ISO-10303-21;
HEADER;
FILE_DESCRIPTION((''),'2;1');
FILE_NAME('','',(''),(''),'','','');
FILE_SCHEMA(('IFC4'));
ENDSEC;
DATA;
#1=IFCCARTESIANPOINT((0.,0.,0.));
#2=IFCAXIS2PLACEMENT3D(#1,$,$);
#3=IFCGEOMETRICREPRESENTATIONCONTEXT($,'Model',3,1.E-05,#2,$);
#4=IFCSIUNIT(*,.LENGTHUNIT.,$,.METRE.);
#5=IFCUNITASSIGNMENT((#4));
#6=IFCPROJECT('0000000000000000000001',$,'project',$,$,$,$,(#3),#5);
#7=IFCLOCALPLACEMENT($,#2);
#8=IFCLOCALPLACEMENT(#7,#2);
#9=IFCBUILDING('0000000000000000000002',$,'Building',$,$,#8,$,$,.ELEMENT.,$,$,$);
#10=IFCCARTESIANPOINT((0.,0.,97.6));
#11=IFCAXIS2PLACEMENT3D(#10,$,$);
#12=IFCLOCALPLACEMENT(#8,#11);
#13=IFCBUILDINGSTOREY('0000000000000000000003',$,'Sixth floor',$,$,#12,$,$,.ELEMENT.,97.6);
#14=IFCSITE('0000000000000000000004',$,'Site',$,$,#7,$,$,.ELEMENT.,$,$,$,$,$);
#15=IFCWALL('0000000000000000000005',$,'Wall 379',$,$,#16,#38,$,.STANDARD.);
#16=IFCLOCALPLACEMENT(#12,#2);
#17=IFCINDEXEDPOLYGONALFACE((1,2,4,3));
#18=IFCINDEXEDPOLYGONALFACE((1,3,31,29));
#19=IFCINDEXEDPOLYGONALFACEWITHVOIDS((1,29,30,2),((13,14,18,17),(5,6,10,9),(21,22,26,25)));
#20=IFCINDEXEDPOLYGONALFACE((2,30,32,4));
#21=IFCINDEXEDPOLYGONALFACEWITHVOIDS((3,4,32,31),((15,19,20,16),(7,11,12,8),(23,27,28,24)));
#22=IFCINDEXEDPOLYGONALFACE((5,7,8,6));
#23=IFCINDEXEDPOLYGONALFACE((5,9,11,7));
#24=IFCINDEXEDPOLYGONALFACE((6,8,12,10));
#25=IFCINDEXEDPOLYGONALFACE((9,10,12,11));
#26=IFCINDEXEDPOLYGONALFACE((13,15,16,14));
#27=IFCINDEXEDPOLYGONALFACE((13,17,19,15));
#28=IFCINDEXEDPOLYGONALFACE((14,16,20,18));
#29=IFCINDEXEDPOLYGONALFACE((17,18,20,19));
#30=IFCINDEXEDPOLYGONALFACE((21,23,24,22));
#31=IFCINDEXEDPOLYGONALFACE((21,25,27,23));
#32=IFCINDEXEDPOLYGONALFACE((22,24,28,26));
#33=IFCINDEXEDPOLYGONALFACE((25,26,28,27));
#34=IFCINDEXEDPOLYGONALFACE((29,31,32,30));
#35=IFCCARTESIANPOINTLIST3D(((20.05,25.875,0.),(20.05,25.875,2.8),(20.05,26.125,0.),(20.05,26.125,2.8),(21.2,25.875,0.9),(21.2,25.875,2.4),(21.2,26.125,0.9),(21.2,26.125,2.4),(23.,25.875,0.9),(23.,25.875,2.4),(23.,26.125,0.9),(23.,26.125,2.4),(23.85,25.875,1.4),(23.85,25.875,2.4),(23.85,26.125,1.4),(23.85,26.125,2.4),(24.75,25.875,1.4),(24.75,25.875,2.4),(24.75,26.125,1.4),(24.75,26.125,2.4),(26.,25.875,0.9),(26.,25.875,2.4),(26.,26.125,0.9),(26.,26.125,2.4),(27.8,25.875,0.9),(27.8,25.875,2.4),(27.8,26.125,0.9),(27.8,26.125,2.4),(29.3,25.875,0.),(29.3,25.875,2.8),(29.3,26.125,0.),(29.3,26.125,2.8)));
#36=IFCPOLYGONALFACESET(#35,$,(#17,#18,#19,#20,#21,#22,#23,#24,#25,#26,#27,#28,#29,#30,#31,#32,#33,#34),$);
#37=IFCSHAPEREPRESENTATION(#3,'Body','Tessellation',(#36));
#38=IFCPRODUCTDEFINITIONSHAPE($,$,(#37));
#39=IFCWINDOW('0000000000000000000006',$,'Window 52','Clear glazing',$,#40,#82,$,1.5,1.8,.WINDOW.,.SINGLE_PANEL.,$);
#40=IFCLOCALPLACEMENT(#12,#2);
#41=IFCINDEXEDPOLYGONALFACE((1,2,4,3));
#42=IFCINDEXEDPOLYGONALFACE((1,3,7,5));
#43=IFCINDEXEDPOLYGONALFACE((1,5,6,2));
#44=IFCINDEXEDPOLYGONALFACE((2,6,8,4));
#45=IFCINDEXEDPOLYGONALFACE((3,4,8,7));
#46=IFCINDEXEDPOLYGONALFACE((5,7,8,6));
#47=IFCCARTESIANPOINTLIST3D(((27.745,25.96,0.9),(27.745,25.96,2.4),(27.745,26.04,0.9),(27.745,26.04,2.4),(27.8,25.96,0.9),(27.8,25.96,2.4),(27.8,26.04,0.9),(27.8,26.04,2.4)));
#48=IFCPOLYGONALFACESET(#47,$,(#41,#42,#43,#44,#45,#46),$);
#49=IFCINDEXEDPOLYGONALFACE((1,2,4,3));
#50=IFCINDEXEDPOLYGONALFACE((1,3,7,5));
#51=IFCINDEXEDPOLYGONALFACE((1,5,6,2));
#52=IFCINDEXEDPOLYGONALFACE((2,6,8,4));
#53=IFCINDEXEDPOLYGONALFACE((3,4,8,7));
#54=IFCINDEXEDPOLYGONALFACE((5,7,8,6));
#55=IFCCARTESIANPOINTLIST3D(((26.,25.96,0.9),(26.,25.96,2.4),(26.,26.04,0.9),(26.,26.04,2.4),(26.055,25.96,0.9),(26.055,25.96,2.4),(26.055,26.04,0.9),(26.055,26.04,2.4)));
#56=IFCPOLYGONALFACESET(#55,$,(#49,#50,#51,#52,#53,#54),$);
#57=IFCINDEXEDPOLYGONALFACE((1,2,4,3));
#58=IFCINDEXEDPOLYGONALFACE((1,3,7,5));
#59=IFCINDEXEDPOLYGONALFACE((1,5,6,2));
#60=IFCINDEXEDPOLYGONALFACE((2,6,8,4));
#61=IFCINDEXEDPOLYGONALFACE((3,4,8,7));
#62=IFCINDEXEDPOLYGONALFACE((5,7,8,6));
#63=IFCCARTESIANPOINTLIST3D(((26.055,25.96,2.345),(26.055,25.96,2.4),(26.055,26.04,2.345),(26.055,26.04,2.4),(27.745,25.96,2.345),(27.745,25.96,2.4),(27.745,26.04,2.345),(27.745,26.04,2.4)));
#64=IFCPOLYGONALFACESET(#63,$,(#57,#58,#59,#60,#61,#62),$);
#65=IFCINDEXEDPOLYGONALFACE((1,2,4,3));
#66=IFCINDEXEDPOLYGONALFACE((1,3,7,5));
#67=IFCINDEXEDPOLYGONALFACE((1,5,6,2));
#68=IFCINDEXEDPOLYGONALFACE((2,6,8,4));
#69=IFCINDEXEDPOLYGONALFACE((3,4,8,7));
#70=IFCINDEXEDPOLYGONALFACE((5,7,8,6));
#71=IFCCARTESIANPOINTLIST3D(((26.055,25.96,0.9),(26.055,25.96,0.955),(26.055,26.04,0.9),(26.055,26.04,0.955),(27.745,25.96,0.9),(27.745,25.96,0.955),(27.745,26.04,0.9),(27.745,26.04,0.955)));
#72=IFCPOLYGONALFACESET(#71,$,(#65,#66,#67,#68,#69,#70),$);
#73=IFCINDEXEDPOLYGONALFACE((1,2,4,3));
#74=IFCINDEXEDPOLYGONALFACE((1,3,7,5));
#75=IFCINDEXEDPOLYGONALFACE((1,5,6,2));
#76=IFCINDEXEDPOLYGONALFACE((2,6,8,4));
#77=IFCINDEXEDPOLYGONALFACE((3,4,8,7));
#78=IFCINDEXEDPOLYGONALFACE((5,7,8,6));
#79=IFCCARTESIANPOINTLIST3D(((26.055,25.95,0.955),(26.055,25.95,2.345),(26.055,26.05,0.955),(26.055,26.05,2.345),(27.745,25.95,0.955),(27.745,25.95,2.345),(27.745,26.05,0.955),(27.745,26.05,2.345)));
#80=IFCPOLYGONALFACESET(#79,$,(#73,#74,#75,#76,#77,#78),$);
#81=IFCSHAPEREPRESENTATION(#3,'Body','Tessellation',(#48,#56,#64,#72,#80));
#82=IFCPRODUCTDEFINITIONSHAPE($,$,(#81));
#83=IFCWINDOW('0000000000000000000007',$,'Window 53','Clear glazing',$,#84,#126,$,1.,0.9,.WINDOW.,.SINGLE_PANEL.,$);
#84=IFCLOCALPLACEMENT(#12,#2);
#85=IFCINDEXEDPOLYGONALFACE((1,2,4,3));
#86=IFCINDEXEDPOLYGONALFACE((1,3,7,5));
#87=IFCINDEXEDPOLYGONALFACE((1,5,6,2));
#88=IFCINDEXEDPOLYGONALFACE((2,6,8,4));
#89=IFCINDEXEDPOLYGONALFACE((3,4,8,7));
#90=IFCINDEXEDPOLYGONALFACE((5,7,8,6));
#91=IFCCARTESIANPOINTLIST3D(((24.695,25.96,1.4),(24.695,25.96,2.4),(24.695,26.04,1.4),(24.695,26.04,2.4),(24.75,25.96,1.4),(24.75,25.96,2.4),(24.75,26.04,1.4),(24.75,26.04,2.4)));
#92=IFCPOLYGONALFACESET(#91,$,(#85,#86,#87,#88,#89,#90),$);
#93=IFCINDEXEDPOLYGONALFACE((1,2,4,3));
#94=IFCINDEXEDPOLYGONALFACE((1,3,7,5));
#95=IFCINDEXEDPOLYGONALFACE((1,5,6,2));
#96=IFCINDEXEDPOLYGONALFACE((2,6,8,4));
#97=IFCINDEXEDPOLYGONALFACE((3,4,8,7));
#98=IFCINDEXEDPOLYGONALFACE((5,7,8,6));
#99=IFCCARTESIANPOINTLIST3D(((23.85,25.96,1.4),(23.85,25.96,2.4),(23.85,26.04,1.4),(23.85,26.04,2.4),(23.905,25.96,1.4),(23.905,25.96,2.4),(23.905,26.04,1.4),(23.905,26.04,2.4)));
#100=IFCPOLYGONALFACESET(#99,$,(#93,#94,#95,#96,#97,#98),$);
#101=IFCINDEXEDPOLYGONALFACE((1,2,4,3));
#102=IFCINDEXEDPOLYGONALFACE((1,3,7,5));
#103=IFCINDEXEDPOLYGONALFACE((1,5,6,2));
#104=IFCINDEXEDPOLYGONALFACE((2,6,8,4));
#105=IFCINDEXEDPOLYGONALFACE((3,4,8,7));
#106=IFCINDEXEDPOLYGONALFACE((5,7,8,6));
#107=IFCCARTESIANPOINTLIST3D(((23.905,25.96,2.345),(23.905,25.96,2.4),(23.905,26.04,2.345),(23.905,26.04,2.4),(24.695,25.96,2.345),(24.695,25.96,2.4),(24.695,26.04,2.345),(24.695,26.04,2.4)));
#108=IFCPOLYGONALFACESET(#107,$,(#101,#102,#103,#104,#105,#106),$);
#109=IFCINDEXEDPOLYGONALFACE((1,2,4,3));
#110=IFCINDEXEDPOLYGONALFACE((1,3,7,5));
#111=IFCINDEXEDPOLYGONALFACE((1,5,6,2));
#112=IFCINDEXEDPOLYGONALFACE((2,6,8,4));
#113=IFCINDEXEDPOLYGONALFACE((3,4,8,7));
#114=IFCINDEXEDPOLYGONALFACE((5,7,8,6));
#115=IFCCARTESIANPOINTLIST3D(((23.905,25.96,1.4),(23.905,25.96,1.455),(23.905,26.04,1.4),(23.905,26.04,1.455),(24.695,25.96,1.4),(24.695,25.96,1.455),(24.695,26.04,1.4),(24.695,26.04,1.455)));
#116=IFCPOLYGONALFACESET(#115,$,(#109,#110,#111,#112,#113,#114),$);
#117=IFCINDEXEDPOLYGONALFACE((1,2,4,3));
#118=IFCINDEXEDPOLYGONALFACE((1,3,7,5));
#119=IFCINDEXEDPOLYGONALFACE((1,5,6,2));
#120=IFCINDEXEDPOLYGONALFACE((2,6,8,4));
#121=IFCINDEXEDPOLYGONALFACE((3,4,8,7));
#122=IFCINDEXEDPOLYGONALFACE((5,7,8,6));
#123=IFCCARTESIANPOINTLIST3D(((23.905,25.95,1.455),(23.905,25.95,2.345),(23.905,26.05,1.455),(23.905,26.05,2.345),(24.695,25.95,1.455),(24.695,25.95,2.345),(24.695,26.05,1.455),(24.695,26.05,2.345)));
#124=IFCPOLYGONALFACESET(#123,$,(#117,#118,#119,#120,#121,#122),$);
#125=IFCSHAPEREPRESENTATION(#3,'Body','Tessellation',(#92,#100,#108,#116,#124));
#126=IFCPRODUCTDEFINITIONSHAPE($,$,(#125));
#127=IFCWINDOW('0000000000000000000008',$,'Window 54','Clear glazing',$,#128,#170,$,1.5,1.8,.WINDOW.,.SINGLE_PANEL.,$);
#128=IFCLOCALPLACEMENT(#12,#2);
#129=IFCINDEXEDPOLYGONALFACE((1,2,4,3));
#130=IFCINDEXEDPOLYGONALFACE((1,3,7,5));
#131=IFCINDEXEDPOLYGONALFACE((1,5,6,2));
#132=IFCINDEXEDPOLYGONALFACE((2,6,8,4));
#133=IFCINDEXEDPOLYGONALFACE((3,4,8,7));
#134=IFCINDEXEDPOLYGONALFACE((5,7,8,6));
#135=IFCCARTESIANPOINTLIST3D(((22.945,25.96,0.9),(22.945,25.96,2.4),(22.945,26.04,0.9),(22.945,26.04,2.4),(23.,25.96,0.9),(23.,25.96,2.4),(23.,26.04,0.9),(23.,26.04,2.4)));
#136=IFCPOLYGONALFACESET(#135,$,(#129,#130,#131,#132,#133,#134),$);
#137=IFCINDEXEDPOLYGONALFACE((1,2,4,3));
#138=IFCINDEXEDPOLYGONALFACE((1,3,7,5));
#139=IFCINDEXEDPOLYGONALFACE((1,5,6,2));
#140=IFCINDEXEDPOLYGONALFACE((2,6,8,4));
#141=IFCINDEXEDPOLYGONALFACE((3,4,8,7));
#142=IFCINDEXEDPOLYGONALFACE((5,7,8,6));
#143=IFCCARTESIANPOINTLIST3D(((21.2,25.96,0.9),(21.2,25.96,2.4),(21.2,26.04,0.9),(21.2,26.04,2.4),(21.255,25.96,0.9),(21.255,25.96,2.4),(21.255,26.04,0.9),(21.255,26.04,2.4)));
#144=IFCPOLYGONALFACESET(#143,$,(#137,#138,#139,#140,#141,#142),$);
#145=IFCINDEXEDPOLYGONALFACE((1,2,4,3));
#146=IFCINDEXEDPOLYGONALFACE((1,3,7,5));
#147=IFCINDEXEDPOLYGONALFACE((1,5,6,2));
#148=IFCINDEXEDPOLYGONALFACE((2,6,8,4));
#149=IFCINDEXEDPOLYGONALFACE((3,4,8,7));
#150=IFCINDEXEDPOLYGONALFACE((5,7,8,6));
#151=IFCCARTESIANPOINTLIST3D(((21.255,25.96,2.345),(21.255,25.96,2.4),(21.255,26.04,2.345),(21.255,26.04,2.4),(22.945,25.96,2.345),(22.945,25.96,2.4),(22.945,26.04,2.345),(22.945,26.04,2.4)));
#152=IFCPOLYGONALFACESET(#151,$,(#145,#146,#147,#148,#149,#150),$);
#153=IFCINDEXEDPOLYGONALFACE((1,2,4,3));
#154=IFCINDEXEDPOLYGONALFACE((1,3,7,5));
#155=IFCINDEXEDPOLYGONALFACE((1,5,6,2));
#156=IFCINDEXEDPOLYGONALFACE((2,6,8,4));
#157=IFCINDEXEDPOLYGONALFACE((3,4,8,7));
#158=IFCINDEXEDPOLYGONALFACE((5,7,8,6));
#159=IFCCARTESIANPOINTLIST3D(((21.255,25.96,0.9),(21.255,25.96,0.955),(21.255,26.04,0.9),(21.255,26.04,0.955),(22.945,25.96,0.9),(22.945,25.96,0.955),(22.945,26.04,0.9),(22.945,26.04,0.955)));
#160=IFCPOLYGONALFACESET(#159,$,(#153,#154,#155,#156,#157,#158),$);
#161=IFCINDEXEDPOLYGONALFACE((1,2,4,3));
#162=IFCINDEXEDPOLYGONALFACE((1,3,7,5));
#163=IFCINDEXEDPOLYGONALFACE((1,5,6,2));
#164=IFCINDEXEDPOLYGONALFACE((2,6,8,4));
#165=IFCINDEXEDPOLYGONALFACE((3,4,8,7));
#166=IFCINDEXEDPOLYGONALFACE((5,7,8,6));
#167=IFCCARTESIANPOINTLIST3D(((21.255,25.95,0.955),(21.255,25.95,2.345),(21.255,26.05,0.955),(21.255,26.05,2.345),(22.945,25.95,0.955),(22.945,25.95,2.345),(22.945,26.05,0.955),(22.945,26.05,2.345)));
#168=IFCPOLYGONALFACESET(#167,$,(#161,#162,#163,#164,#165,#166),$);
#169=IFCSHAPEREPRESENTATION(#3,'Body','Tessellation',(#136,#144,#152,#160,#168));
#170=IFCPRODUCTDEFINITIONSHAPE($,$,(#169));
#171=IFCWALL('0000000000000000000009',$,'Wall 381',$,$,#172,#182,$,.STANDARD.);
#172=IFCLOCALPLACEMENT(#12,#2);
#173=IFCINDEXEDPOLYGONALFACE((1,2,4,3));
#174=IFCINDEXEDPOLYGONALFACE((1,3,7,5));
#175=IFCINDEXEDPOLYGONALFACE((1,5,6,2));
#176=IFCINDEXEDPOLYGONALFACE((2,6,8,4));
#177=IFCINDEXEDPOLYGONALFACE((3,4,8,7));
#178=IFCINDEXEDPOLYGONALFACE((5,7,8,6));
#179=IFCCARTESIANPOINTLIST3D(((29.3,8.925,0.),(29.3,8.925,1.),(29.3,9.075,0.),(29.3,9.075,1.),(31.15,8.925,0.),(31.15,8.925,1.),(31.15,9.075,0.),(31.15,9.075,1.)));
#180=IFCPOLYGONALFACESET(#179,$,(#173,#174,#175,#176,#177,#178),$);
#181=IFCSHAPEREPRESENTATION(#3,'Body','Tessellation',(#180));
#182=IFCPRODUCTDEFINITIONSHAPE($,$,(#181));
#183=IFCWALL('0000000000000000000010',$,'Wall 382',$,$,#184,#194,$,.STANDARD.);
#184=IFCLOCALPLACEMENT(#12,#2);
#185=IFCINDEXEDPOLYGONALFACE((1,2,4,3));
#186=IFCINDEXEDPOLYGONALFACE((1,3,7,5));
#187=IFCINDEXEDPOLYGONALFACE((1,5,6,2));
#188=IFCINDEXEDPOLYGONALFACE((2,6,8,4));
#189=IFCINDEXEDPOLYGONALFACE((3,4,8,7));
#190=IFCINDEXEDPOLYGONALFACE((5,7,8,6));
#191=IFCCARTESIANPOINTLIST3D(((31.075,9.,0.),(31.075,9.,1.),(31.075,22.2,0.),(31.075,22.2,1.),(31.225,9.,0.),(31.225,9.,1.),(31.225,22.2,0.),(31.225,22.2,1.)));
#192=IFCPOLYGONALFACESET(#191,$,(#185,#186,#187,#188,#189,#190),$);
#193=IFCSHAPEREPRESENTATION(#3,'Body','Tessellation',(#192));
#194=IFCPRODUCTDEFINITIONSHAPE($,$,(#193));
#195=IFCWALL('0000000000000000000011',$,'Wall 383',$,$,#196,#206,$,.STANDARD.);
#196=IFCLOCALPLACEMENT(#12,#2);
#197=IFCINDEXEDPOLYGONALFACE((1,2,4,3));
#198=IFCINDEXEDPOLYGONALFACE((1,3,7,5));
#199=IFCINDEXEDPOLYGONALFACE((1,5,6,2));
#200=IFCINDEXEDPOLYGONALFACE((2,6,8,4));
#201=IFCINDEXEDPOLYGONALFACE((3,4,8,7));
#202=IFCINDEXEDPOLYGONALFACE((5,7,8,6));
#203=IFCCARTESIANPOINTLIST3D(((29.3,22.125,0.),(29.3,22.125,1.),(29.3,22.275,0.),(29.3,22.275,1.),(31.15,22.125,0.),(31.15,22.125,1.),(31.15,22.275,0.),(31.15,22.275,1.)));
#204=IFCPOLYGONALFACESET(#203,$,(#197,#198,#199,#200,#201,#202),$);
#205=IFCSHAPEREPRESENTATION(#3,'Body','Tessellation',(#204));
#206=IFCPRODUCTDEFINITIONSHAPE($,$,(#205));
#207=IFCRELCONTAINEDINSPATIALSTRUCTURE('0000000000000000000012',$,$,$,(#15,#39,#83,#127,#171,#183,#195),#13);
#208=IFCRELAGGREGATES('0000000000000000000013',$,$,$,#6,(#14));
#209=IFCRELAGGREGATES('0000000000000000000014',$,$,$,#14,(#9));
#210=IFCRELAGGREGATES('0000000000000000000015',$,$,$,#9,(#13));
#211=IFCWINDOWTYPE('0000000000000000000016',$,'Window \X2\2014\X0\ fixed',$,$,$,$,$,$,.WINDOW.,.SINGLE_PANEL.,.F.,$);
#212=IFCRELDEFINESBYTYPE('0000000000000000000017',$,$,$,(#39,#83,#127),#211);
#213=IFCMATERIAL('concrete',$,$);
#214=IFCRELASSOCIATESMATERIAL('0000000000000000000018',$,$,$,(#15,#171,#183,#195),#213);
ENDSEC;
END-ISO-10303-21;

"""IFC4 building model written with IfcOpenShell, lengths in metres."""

from ifc_helpers import new_model, si_unit, frame, frame_2d, origin, place, context, project, spatial, rectangle, extrude, material, type_object, element, fill, save


model = new_model("IFC4")

# Units and contexts
model_context = context("Model", 3, precision=1e-05, world=origin())
ifc_project = project(units=[si_unit("LENGTHUNIT", "METRE")], contexts=[model_context])

# Site, building, storey
site_placement = place(None, origin())
site = spatial("IfcSite", under=ifc_project, at=site_placement, Name="Site", CompositionType="ELEMENT")
building_placement = place(site_placement, origin())
building = spatial("IfcBuilding", under=site, at=building_placement, Name="Building", CompositionType="ELEMENT")
storey_placement = place(building_placement, frame((0.0, 0.0, 97.6)))
storey = spatial("IfcBuildingStorey", under=building, at=storey_placement, Name="Sixth floor", CompositionType="ELEMENT", Elevation=97.6)

# Shared definitions
ifc_material = material(Name="concrete")

# Shared definitions
window_type = type_object("IfcWindowType", Name="Window — fixed", ParameterTakesPrecedence=False, PartitioningType="SINGLE_PANEL", PredefinedType="WINDOW")

# Wall, openings, windows
wall_1_placement = place(storey_placement, frame((29.3, 26.0, 0.0), z_axis=(0.0, 0.0, 1.0), x_axis=(-1.0, 0.0, 0.0)))
wall_1 = element("IfcWall", 1, at=wall_1_placement, inside=storey, material=ifc_material, Name="Wall 379", PredefinedType="STANDARD", context=model_context, shape_type="SweptSolid", body=[
    extrude(rectangle(XDim=9.25, YDim=0.25, at=frame_2d((4.625, 0.0))), origin(), (0.0, 0.0, 1.0), 2.8),
])
opening_1_placement = place(storey_placement, frame((27.8, 26.0, 0.9), z_axis=(0.0, 0.0, 1.0), x_axis=(-1.0, 0.0, 0.0)))
opening_1 = element("IfcOpeningElement", 2, at=opening_1_placement, cuts=wall_1, PredefinedType="OPENING", context=model_context, shape_type="SweptSolid", body=[
    extrude(rectangle(XDim=1.8, YDim=0.31, at=frame_2d((0.9, 0.0))), origin(), (0.0, 0.0, 1.0), 1.5),
])
opening_2_placement = place(storey_placement, frame((24.75, 26.0, 1.4), z_axis=(0.0, 0.0, 1.0), x_axis=(-1.0, 0.0, 0.0)))
opening_2 = element("IfcOpeningElement", 3, at=opening_2_placement, cuts=wall_1, PredefinedType="OPENING", context=model_context, shape_type="SweptSolid", body=[
    extrude(rectangle(XDim=0.9, YDim=0.31, at=frame_2d((0.45, 0.0))), origin(), (0.0, 0.0, 1.0), 1.0),
])
opening_3_placement = place(storey_placement, frame((23.0, 26.0, 0.9), z_axis=(0.0, 0.0, 1.0), x_axis=(-1.0, 0.0, 0.0)))
opening_3 = element("IfcOpeningElement", 4, at=opening_3_placement, cuts=wall_1, PredefinedType="OPENING", context=model_context, shape_type="SweptSolid", body=[
    extrude(rectangle(XDim=1.8, YDim=0.31, at=frame_2d((0.9, 0.0))), origin(), (0.0, 0.0, 1.0), 1.5),
])
window_1_placement = place(storey_placement, frame((27.8, 26.0, 0.9), z_axis=(0.0, 0.0, 1.0), x_axis=(-1.0, 0.0, 0.0)))
window_1 = element("IfcWindow", 5, at=window_1_placement, inside=storey, type_object=window_type, Name="Window 52", Description="Clear glazing", OverallHeight=1.5, OverallWidth=1.8, PartitioningType="SINGLE_PANEL", PredefinedType="WINDOW", context=model_context, shape_type="SweptSolid", body=[
    extrude(rectangle(XDim=0.055, YDim=0.08, at=frame_2d((0.0275, 0.0))), origin(), (0.0, 0.0, 1.0), 1.5),
    extrude(rectangle(XDim=0.055, YDim=0.08, at=frame_2d((1.7725, 0.0))), origin(), (0.0, 0.0, 1.0), 1.5),
    extrude(rectangle(XDim=1.69, YDim=0.08, at=frame_2d((0.9, 0.0))), frame((0.0, 0.0, 1.445)), (0.0, 0.0, 1.0), 0.055),
    extrude(rectangle(XDim=1.69, YDim=0.08, at=frame_2d((0.9, 0.0))), origin(), (0.0, 0.0, 1.0), 0.055),
    extrude(rectangle(XDim=1.69, YDim=0.1, at=frame_2d((0.9, 0.0))), frame((0.0, 0.0, 0.055)), (0.0, 0.0, 1.0), 1.39),
])
fill(opening_1, window_1)
window_2_placement = place(storey_placement, frame((24.75, 26.0, 1.4), z_axis=(0.0, 0.0, 1.0), x_axis=(-1.0, 0.0, 0.0)))
window_2 = element("IfcWindow", 6, at=window_2_placement, inside=storey, type_object=window_type, Name="Window 53", Description="Clear glazing", OverallHeight=1.0, OverallWidth=0.9, PartitioningType="SINGLE_PANEL", PredefinedType="WINDOW", context=model_context, shape_type="SweptSolid", body=[
    extrude(rectangle(XDim=0.055, YDim=0.08, at=frame_2d((0.0275, 0.0))), origin(), (0.0, 0.0, 1.0), 1.0),
    extrude(rectangle(XDim=0.055, YDim=0.08, at=frame_2d((0.8725, 0.0))), origin(), (0.0, 0.0, 1.0), 1.0),
    extrude(rectangle(XDim=0.79, YDim=0.08, at=frame_2d((0.45, 0.0))), frame((0.0, 0.0, 0.945)), (0.0, 0.0, 1.0), 0.055),
    extrude(rectangle(XDim=0.79, YDim=0.08, at=frame_2d((0.45, 0.0))), origin(), (0.0, 0.0, 1.0), 0.055),
    extrude(rectangle(XDim=0.79, YDim=0.1, at=frame_2d((0.45, 0.0))), frame((0.0, 0.0, 0.055)), (0.0, 0.0, 1.0), 0.89),
])
fill(opening_2, window_2)
window_3_placement = place(storey_placement, frame((23.0, 26.0, 0.9), z_axis=(0.0, 0.0, 1.0), x_axis=(-1.0, 0.0, 0.0)))
window_3 = element("IfcWindow", 7, at=window_3_placement, inside=storey, type_object=window_type, Name="Window 54", Description="Clear glazing", OverallHeight=1.5, OverallWidth=1.8, PartitioningType="SINGLE_PANEL", PredefinedType="WINDOW", context=model_context, shape_type="SweptSolid", body=[
    extrude(rectangle(XDim=0.055, YDim=0.08, at=frame_2d((0.0275, 0.0))), origin(), (0.0, 0.0, 1.0), 1.5),
    extrude(rectangle(XDim=0.055, YDim=0.08, at=frame_2d((1.7725, 0.0))), origin(), (0.0, 0.0, 1.0), 1.5),
    extrude(rectangle(XDim=1.69, YDim=0.08, at=frame_2d((0.9, 0.0))), frame((0.0, 0.0, 1.445)), (0.0, 0.0, 1.0), 0.055),
    extrude(rectangle(XDim=1.69, YDim=0.08, at=frame_2d((0.9, 0.0))), origin(), (0.0, 0.0, 1.0), 0.055),
    extrude(rectangle(XDim=1.69, YDim=0.1, at=frame_2d((0.9, 0.0))), frame((0.0, 0.0, 0.055)), (0.0, 0.0, 1.0), 1.39),
])
fill(opening_3, window_3)

# Walls
wall_2_placement = place(storey_placement, frame((29.3, 9.0, 0.0), z_axis=(0.0, 0.0, 1.0), x_axis=(1.0, 0.0, 0.0)))
element("IfcWall", 8, at=wall_2_placement, inside=storey, material=ifc_material, Name="Wall 381", PredefinedType="STANDARD", context=model_context, shape_type="SweptSolid", body=[
    extrude(rectangle(XDim=1.85, YDim=0.15, at=frame_2d((0.925, 0.0))), origin(), (0.0, 0.0, 1.0), 1.0),
])
wall_3_placement = place(storey_placement, frame((31.15, 9.0, 0.0), z_axis=(0.0, 0.0, 1.0), x_axis=(0.0, 1.0, 0.0)))
element("IfcWall", 9, at=wall_3_placement, inside=storey, material=ifc_material, Name="Wall 382", PredefinedType="STANDARD", context=model_context, shape_type="SweptSolid", body=[
    extrude(rectangle(XDim=13.2, YDim=0.15, at=frame_2d((6.6, 0.0))), origin(), (0.0, 0.0, 1.0), 1.0),
])
wall_4_placement = place(storey_placement, frame((31.15, 22.2, 0.0), z_axis=(0.0, 0.0, 1.0), x_axis=(-1.0, 0.0, 0.0)))
element("IfcWall", 10, at=wall_4_placement, inside=storey, material=ifc_material, Name="Wall 383", PredefinedType="STANDARD", context=model_context, shape_type="SweptSolid", body=[
    extrude(rectangle(XDim=1.85, YDim=0.15, at=frame_2d((0.925, 0.0))), origin(), (0.0, 0.0, 1.0), 1.0),
])

save(model, "model.ifc")
